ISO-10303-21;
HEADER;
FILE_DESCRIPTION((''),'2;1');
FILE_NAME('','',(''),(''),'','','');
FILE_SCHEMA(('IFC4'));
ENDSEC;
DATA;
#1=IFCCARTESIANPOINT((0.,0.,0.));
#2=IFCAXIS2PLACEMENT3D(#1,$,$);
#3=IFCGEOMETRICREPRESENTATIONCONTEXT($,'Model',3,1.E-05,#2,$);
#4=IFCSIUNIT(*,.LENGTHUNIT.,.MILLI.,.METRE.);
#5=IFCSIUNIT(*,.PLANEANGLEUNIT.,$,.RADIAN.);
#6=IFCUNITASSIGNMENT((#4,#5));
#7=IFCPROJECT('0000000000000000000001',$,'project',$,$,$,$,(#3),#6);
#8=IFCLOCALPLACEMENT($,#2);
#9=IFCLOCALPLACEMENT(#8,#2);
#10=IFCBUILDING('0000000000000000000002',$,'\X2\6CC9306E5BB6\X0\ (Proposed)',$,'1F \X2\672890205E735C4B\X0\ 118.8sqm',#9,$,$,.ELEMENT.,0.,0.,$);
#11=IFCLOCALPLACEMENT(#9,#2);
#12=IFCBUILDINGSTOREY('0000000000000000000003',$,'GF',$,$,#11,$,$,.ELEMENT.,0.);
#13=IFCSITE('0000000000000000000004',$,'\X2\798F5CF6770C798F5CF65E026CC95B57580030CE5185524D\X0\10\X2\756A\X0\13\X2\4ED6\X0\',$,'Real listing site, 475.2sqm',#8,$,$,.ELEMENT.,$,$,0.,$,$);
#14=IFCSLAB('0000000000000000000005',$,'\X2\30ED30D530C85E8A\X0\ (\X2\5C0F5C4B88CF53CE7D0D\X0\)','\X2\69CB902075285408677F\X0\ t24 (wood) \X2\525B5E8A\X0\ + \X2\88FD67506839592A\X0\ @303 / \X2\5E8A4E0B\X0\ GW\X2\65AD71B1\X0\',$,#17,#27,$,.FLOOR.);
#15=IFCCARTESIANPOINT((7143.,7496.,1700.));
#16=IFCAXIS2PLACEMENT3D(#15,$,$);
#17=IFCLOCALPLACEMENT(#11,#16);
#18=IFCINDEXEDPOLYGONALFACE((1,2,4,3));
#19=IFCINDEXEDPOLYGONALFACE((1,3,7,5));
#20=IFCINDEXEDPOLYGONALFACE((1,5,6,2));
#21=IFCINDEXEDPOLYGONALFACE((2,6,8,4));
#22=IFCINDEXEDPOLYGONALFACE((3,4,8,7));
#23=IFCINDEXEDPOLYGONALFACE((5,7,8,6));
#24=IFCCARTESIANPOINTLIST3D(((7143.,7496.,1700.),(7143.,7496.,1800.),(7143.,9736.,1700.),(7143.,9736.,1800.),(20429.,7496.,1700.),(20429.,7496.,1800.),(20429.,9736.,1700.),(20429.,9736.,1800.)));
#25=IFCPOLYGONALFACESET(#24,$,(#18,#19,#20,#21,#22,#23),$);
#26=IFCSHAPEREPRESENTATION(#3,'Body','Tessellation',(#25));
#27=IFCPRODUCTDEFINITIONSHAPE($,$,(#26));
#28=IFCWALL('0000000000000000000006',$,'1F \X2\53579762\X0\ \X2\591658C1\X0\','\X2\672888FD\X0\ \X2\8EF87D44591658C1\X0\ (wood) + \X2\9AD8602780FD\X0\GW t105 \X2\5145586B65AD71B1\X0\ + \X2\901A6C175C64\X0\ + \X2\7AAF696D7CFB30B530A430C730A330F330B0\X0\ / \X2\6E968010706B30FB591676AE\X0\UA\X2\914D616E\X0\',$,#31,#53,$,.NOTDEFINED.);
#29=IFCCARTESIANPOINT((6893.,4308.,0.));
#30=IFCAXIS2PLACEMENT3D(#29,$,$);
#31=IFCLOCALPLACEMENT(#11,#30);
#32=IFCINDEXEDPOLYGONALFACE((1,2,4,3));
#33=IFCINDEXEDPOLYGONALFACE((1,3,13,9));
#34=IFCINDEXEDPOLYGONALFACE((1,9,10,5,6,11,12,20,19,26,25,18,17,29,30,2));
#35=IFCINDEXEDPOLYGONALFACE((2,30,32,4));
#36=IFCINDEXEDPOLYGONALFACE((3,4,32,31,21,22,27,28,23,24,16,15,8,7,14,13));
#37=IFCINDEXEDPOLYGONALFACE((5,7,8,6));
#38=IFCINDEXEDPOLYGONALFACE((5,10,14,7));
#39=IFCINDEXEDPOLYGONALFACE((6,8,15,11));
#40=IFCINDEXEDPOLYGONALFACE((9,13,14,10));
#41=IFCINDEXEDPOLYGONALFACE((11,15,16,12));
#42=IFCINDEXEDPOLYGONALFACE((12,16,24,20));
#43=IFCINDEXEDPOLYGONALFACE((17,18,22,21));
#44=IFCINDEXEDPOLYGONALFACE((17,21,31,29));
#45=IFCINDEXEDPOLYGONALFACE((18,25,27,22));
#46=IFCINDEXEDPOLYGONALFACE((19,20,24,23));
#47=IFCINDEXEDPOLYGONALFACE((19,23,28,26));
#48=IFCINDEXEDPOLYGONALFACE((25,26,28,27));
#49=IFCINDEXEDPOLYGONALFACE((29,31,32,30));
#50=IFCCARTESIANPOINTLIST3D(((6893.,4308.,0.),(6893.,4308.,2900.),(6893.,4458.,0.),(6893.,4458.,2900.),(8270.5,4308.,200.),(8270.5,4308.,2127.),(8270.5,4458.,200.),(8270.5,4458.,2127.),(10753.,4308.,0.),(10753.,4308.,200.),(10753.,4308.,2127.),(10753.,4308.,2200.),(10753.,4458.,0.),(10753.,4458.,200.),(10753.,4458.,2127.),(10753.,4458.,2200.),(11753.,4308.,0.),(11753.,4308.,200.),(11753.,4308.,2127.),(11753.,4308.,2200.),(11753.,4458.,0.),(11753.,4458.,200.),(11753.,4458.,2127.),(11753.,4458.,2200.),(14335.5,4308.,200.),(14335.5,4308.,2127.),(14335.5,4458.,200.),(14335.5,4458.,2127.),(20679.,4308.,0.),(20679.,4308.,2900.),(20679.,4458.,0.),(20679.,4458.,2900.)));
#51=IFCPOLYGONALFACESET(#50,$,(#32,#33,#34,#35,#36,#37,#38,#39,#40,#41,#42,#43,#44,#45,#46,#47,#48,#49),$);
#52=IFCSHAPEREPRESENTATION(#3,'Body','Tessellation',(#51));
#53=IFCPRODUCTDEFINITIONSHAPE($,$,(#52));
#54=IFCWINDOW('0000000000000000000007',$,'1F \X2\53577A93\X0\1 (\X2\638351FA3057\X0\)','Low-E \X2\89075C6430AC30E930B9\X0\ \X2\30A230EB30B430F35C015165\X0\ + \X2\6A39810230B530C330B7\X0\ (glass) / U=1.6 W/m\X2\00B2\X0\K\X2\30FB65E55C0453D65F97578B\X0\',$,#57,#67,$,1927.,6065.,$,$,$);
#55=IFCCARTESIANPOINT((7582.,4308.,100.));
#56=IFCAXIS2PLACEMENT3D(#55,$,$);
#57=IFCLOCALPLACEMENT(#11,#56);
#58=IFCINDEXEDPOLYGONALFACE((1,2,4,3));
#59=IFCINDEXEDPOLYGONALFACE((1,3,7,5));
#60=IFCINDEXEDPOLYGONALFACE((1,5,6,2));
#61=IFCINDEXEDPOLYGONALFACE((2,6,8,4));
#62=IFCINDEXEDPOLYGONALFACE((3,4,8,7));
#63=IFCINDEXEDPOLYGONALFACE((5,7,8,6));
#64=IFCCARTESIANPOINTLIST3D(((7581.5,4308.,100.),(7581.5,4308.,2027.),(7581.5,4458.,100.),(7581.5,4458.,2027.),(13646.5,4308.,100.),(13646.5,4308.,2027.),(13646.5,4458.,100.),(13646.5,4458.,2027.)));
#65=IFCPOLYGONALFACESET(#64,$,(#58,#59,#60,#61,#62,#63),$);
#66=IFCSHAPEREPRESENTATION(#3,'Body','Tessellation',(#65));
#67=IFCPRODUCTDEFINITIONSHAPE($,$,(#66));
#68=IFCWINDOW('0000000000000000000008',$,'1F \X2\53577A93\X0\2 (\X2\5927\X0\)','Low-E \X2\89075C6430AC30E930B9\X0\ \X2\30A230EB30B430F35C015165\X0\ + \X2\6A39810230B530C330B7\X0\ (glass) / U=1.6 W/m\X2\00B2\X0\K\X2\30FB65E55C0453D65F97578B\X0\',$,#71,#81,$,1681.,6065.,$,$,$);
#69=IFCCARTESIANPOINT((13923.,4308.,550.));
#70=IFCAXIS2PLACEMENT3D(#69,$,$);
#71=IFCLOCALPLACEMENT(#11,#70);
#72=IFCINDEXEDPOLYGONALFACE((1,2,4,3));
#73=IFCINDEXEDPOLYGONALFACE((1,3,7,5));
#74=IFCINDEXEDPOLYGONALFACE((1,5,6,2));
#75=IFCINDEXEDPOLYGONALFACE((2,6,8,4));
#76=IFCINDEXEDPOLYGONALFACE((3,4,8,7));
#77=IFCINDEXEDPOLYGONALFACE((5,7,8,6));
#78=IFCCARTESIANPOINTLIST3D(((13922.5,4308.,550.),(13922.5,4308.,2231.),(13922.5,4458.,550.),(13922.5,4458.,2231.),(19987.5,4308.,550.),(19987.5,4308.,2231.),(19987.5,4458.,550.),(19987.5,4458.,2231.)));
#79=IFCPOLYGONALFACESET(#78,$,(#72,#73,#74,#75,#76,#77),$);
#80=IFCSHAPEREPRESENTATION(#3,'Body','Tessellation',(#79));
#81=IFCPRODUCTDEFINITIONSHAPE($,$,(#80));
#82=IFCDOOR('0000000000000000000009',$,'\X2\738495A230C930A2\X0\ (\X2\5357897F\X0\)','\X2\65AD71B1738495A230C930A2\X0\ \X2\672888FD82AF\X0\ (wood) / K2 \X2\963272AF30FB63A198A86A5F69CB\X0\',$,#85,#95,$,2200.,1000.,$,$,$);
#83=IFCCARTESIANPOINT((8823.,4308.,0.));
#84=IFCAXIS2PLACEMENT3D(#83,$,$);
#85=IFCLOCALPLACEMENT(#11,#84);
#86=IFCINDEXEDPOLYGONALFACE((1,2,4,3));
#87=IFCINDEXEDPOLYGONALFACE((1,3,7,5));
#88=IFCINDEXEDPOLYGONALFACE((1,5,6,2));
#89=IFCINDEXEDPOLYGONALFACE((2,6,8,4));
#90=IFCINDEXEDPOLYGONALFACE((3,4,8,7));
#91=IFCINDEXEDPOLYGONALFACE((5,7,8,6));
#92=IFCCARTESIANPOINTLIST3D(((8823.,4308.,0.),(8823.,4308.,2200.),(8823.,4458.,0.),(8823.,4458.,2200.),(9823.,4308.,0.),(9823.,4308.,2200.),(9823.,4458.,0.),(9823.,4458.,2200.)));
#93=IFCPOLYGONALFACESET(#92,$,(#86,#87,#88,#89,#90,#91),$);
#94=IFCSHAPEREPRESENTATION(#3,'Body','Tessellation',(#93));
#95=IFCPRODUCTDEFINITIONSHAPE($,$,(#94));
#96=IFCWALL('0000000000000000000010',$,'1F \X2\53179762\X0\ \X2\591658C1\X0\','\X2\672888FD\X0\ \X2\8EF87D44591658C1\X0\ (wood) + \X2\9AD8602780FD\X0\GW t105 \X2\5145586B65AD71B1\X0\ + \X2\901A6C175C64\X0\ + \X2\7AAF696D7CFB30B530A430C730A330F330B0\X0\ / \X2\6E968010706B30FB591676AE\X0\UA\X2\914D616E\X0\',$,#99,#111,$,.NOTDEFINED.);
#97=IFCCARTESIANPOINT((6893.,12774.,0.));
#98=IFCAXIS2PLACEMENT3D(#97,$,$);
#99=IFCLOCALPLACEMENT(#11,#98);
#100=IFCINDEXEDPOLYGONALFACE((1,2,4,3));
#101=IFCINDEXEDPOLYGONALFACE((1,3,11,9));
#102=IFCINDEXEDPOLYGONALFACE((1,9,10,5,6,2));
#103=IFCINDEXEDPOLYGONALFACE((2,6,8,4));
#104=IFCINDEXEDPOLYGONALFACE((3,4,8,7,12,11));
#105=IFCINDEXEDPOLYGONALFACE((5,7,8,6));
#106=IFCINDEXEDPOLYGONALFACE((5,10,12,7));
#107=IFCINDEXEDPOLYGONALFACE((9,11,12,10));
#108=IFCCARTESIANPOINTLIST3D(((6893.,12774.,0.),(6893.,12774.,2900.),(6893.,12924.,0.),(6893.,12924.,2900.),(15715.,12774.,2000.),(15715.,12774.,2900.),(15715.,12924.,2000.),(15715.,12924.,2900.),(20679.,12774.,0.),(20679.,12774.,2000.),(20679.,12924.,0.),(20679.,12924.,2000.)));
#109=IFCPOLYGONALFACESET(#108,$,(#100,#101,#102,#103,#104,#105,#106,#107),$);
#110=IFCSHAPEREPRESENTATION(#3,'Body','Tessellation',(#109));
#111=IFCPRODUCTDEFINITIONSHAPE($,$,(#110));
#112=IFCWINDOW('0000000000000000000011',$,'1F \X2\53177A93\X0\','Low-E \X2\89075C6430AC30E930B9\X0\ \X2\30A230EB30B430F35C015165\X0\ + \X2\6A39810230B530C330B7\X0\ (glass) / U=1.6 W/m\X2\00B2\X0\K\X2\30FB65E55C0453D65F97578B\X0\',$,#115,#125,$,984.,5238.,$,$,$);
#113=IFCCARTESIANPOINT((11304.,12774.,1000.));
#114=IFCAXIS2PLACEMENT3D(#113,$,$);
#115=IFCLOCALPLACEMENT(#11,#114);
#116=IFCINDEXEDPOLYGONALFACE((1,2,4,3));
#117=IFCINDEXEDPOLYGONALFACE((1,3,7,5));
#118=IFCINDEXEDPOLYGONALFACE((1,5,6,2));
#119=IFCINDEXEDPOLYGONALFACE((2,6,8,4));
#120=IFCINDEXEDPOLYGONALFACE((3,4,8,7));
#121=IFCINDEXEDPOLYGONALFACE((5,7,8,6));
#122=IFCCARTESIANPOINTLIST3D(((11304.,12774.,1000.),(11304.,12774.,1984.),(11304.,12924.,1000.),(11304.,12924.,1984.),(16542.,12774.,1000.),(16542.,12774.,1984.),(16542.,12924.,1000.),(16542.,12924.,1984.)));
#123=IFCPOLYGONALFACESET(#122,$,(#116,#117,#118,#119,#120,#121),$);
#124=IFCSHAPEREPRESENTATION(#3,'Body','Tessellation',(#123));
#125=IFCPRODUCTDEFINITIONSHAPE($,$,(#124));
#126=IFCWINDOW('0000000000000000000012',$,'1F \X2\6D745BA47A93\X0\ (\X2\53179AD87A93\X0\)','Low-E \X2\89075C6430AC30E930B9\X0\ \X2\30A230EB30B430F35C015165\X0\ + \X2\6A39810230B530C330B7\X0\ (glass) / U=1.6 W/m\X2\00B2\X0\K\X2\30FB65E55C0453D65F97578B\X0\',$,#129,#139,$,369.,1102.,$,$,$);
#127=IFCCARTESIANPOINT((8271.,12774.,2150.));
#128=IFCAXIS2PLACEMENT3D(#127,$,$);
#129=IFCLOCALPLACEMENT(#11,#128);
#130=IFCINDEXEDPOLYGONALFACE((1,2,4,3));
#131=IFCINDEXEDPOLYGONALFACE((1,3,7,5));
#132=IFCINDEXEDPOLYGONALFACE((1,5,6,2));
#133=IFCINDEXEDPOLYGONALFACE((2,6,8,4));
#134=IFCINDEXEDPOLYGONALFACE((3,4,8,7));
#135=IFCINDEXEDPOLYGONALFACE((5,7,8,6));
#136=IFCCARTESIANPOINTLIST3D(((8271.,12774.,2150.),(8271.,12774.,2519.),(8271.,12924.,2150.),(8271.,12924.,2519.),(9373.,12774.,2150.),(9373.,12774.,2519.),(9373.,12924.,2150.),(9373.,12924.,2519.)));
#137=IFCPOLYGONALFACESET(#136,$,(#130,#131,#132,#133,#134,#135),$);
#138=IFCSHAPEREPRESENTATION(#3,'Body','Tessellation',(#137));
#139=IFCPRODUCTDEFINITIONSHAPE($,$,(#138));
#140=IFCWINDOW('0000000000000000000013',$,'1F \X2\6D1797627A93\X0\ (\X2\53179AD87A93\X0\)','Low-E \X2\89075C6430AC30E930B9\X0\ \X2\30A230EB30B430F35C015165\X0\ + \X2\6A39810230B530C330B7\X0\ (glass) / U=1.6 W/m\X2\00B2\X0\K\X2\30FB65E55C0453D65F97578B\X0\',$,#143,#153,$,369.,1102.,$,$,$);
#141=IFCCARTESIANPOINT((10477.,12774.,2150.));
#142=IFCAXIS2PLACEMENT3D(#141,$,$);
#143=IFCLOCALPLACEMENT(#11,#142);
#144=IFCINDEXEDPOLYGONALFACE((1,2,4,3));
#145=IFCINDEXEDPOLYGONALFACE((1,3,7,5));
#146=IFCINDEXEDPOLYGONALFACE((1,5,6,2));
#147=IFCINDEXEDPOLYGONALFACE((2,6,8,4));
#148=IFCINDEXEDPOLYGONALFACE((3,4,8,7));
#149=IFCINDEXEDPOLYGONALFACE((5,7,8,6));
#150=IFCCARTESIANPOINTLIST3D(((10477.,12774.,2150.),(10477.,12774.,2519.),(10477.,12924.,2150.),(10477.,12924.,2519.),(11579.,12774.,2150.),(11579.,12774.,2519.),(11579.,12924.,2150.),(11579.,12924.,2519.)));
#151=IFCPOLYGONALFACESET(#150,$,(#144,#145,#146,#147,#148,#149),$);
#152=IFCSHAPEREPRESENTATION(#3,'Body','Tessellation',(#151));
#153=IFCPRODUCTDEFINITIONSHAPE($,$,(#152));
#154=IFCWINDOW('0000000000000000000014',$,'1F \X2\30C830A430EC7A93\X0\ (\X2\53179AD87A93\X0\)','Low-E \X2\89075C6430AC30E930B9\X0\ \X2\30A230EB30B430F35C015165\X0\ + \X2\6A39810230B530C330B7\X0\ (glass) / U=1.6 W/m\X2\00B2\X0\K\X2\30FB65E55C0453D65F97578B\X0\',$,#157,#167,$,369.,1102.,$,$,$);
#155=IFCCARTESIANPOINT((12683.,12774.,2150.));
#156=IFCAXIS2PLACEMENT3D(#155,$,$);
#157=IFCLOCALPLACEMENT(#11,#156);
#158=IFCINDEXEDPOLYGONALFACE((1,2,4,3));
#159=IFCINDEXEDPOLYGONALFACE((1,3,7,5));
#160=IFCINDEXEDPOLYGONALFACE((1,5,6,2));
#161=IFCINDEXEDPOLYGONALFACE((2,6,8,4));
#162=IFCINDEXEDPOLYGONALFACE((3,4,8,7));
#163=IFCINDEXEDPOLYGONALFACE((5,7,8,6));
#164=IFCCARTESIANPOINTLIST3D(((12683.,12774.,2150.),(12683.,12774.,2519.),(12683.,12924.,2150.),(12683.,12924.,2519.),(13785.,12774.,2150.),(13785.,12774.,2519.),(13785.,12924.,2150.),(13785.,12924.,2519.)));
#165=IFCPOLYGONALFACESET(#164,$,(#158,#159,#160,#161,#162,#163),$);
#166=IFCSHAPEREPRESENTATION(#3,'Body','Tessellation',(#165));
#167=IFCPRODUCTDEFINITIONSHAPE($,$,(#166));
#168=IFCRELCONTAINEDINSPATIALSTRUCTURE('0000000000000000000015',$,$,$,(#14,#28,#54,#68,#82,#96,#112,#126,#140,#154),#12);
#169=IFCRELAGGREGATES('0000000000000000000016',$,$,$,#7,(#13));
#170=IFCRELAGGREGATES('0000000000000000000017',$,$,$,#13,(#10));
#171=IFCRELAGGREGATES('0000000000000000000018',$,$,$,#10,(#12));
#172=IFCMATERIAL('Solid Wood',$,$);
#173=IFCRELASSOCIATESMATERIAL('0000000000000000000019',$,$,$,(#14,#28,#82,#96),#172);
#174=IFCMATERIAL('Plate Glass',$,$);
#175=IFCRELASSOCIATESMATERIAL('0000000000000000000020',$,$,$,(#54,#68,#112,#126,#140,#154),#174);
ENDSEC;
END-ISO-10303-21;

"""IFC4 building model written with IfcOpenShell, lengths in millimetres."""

from ifc_helpers import new_model, si_unit, frame, frame_2d, origin, place, context, project, spatial, rectangle, extrude, material, element, fill, save


model = new_model("IFC4")

# Units and contexts
model_context = context("Model", 3, precision=1e-05, world=origin())
ifc_project = project(units=[si_unit("LENGTHUNIT", "METRE", prefix="MILLI"), si_unit("PLANEANGLEUNIT", "RADIAN")], contexts=[model_context])

# Site, building, storey
site_placement = place(None, origin())
site = spatial("IfcSite", under=ifc_project, at=site_placement, Name="福島県福島市泉字堀ノ内前10番13他", ObjectType="Real listing site, 475.2sqm", CompositionType="ELEMENT", RefElevation=0.0)
building_placement = place(site_placement, origin())
building = spatial("IfcBuilding", under=site, at=building_placement, Name="泉の家 (Proposed)", ObjectType="1F 木造平屋 118.8sqm", CompositionType="ELEMENT", ElevationOfRefHeight=0.0, ElevationOfTerrain=0.0)
storey_placement = place(building_placement, origin())
storey = spatial("IfcBuildingStorey", under=building, at=storey_placement, Name="GF", CompositionType="ELEMENT", Elevation=0.0)

# Slab
ifc_material_1 = material(Name="Solid Wood")
slab_1_placement = place(storey_placement, frame((7143.0, 7496.0, 1700.0)))
element("IfcSlab", 1, at=slab_1_placement, inside=storey, material=ifc_material_1, Name="ロフト床 (小屋裏収納)", Description="構造用合板 t24 (wood) 剛床 + 製材根太 @303 / 床下 GW断熱", PredefinedType="FLOOR", context=model_context, shape_type="SweptSolid", body=[
    extrude(rectangle(XDim=13286.0, YDim=2240.0, at=frame_2d((6643.0, 1120.0))), frame((7143.0, 7496.0, 1700.0)), (0.0, 0.0, 1.0), 100.0),
])

# Wall, openings, windows, door
wall_1_placement = place(storey_placement, frame((6893.0, 4308.0, 0.0)))
wall_1 = element("IfcWall", 2, at=wall_1_placement, inside=storey, material=ifc_material_1, Name="1F 南面 外壁", Description="木製 軸組外壁 (wood) + 高性能GW t105 充填断熱 + 通気層 + 窯業系サイディング / 準耐火・外皮UA配慮", PredefinedType="NOTDEFINED", context=model_context, shape_type="SweptSolid", body=[
    extrude(rectangle(XDim=13786.0, YDim=150.0, at=frame_2d((6893.0, 75.0))), frame((6893.0, 4308.0, 0.0)), (0.0, 0.0, 1.0), 2900.0),
])
opening_1_placement = place(storey_placement, frame((7582.0, 4308.0, 100.0)))
opening_1 = element("IfcOpeningElement", 3, at=opening_1_placement, cuts=wall_1, PredefinedType="NOTDEFINED", context=model_context, shape_type="SweptSolid", body=[
    extrude(rectangle(XDim=6065.0, YDim=150.0, at=frame_2d((3032.0, 75.0))), frame((7582.0, 4308.0, 100.0)), (0.0, 0.0, 1.0), 1927.0),
])
opening_2_placement = place(storey_placement, frame((13923.0, 4308.0, 550.0)))
opening_2 = element("IfcOpeningElement", 4, at=opening_2_placement, cuts=wall_1, PredefinedType="NOTDEFINED", context=model_context, shape_type="SweptSolid", body=[
    extrude(rectangle(XDim=6065.0, YDim=150.0, at=frame_2d((3032.0, 75.0))), frame((13923.0, 4308.0, 550.0)), (0.0, 0.0, 1.0), 1681.0),
])
opening_3_placement = place(storey_placement, frame((8823.0, 4308.0, 0.0)))
opening_3 = element("IfcOpeningElement", 5, at=opening_3_placement, cuts=wall_1, PredefinedType="NOTDEFINED", context=model_context, shape_type="SweptSolid", body=[
    extrude(rectangle(XDim=1000.0, YDim=150.0, at=frame_2d((500.0, 75.0))), frame((8823.0, 4308.0, 0.0)), (0.0, 0.0, 1.0), 2200.0),
])
ifc_material_2 = material(Name="Plate Glass")
window_1_placement = place(storey_placement, frame((7582.0, 4308.0, 100.0)))
window_1 = element("IfcWindow", 6, at=window_1_placement, inside=storey, material=ifc_material_2, Name="1F 南窓1 (掃出し)", Description="Low-E 複層ガラス アルゴン封入 + 樹脂サッシ (glass) / U=1.6 W/m²K・日射取得型", OverallHeight=1927.0, OverallWidth=6065.0, context=model_context, shape_type="SweptSolid", body=[
    extrude(rectangle(XDim=6065.0, YDim=150.0, at=frame_2d((3032.0, 75.0))), frame((7582.0, 4308.0, 100.0)), (0.0, 0.0, 1.0), 1927.0),
])
fill(opening_1, window_1)
window_2_placement = place(storey_placement, frame((13923.0, 4308.0, 550.0)))
window_2 = element("IfcWindow", 7, at=window_2_placement, inside=storey, material=ifc_material_2, Name="1F 南窓2 (大)", Description="Low-E 複層ガラス アルゴン封入 + 樹脂サッシ (glass) / U=1.6 W/m²K・日射取得型", OverallHeight=1681.0, OverallWidth=6065.0, context=model_context, shape_type="SweptSolid", body=[
    extrude(rectangle(XDim=6065.0, YDim=150.0, at=frame_2d((3032.0, 75.0))), frame((13923.0, 4308.0, 550.0)), (0.0, 0.0, 1.0), 1681.0),
])
fill(opening_2, window_2)
door_1_placement = place(storey_placement, frame((8823.0, 4308.0, 0.0)))
door_1 = element("IfcDoor", 8, at=door_1_placement, inside=storey, material=ifc_material_1, Name="玄関ドア (南西)", Description="断熱玄関ドア 木製芯 (wood) / K2 防犯・採風機構", OverallHeight=2200.0, OverallWidth=1000.0, context=model_context, shape_type="SweptSolid", body=[
    extrude(rectangle(XDim=1000.0, YDim=150.0, at=frame_2d((500.0, 75.0))), frame((8823.0, 4308.0, 0.0)), (0.0, 0.0, 1.0), 2200.0),
])
fill(opening_3, door_1)

# Wall, openings, windows
wall_2_placement = place(storey_placement, frame((6893.0, 12774.0, 0.0)))
wall_2 = element("IfcWall", 9, at=wall_2_placement, inside=storey, material=ifc_material_1, Name="1F 北面 外壁", Description="木製 軸組外壁 (wood) + 高性能GW t105 充填断熱 + 通気層 + 窯業系サイディング / 準耐火・外皮UA配慮", PredefinedType="NOTDEFINED", context=model_context, shape_type="SweptSolid", body=[
    extrude(rectangle(XDim=13786.0, YDim=150.0, at=frame_2d((6893.0, 75.0))), frame((6893.0, 12774.0, 0.0)), (0.0, 0.0, 1.0), 2900.0),
])
opening_4_placement = place(storey_placement, frame((11304.0, 12774.0, 1000.0)))
opening_4 = element("IfcOpeningElement", 10, at=opening_4_placement, cuts=wall_2, PredefinedType="NOTDEFINED", context=model_context, shape_type="SweptSolid", body=[
    extrude(rectangle(XDim=5238.0, YDim=150.0, at=frame_2d((2619.0, 75.0))), frame((11304.0, 12774.0, 1000.0)), (0.0, 0.0, 1.0), 984.0),
])
opening_5_placement = place(storey_placement, frame((8271.0, 12774.0, 2150.0)))
opening_5 = element("IfcOpeningElement", 11, at=opening_5_placement, cuts=wall_2, PredefinedType="NOTDEFINED", context=model_context, shape_type="SweptSolid", body=[
    extrude(rectangle(XDim=1102.0, YDim=150.0, at=frame_2d((551.0, 75.0))), frame((8271.0, 12774.0, 2150.0)), (0.0, 0.0, 1.0), 369.0),
])
opening_6_placement = place(storey_placement, frame((10477.0, 12774.0, 2150.0)))
opening_6 = element("IfcOpeningElement", 12, at=opening_6_placement, cuts=wall_2, PredefinedType="NOTDEFINED", context=model_context, shape_type="SweptSolid", body=[
    extrude(rectangle(XDim=1102.0, YDim=150.0, at=frame_2d((551.0, 75.0))), frame((10477.0, 12774.0, 2150.0)), (0.0, 0.0, 1.0), 369.0),
])
opening_7_placement = place(storey_placement, frame((12683.0, 12774.0, 2150.0)))
opening_7 = element("IfcOpeningElement", 13, at=opening_7_placement, cuts=wall_2, PredefinedType="NOTDEFINED", context=model_context, shape_type="SweptSolid", body=[
    extrude(rectangle(XDim=1102.0, YDim=150.0, at=frame_2d((551.0, 75.0))), frame((12683.0, 12774.0, 2150.0)), (0.0, 0.0, 1.0), 369.0),
])
window_3_placement = place(storey_placement, frame((11304.0, 12774.0, 1000.0)))
window_3 = element("IfcWindow", 14, at=window_3_placement, inside=storey, material=ifc_material_2, Name="1F 北窓", Description="Low-E 複層ガラス アルゴン封入 + 樹脂サッシ (glass) / U=1.6 W/m²K・日射取得型", OverallHeight=984.0, OverallWidth=5238.0, context=model_context, shape_type="SweptSolid", body=[
    extrude(rectangle(XDim=5238.0, YDim=150.0, at=frame_2d((2619.0, 75.0))), frame((11304.0, 12774.0, 1000.0)), (0.0, 0.0, 1.0), 984.0),
])
fill(opening_4, window_3)
window_4_placement = place(storey_placement, frame((8271.0, 12774.0, 2150.0)))
window_4 = element("IfcWindow", 15, at=window_4_placement, inside=storey, material=ifc_material_2, Name="1F 浴室窓 (北高窓)", Description="Low-E 複層ガラス アルゴン封入 + 樹脂サッシ (glass) / U=1.6 W/m²K・日射取得型", OverallHeight=369.0, OverallWidth=1102.0, context=model_context, shape_type="SweptSolid", body=[
    extrude(rectangle(XDim=1102.0, YDim=150.0, at=frame_2d((551.0, 75.0))), frame((8271.0, 12774.0, 2150.0)), (0.0, 0.0, 1.0), 369.0),
])
fill(opening_5, window_4)
window_5_placement = place(storey_placement, frame((10477.0, 12774.0, 2150.0)))
window_5 = element("IfcWindow", 16, at=window_5_placement, inside=storey, material=ifc_material_2, Name="1F 洗面窓 (北高窓)", Description="Low-E 複層ガラス アルゴン封入 + 樹脂サッシ (glass) / U=1.6 W/m²K・日射取得型", OverallHeight=369.0, OverallWidth=1102.0, context=model_context, shape_type="SweptSolid", body=[
    extrude(rectangle(XDim=1102.0, YDim=150.0, at=frame_2d((551.0, 75.0))), frame((10477.0, 12774.0, 2150.0)), (0.0, 0.0, 1.0), 369.0),
])
fill(opening_6, window_5)
window_6_placement = place(storey_placement, frame((12683.0, 12774.0, 2150.0)))
window_6 = element("IfcWindow", 17, at=window_6_placement, inside=storey, material=ifc_material_2, Name="1F トイレ窓 (北高窓)", Description="Low-E 複層ガラス アルゴン封入 + 樹脂サッシ (glass) / U=1.6 W/m²K・日射取得型", OverallHeight=369.0, OverallWidth=1102.0, context=model_context, shape_type="SweptSolid", body=[
    extrude(rectangle(XDim=1102.0, YDim=150.0, at=frame_2d((551.0, 75.0))), frame((12683.0, 12774.0, 2150.0)), (0.0, 0.0, 1.0), 369.0),
])
fill(opening_7, window_6)

save(model, "model.ifc")
